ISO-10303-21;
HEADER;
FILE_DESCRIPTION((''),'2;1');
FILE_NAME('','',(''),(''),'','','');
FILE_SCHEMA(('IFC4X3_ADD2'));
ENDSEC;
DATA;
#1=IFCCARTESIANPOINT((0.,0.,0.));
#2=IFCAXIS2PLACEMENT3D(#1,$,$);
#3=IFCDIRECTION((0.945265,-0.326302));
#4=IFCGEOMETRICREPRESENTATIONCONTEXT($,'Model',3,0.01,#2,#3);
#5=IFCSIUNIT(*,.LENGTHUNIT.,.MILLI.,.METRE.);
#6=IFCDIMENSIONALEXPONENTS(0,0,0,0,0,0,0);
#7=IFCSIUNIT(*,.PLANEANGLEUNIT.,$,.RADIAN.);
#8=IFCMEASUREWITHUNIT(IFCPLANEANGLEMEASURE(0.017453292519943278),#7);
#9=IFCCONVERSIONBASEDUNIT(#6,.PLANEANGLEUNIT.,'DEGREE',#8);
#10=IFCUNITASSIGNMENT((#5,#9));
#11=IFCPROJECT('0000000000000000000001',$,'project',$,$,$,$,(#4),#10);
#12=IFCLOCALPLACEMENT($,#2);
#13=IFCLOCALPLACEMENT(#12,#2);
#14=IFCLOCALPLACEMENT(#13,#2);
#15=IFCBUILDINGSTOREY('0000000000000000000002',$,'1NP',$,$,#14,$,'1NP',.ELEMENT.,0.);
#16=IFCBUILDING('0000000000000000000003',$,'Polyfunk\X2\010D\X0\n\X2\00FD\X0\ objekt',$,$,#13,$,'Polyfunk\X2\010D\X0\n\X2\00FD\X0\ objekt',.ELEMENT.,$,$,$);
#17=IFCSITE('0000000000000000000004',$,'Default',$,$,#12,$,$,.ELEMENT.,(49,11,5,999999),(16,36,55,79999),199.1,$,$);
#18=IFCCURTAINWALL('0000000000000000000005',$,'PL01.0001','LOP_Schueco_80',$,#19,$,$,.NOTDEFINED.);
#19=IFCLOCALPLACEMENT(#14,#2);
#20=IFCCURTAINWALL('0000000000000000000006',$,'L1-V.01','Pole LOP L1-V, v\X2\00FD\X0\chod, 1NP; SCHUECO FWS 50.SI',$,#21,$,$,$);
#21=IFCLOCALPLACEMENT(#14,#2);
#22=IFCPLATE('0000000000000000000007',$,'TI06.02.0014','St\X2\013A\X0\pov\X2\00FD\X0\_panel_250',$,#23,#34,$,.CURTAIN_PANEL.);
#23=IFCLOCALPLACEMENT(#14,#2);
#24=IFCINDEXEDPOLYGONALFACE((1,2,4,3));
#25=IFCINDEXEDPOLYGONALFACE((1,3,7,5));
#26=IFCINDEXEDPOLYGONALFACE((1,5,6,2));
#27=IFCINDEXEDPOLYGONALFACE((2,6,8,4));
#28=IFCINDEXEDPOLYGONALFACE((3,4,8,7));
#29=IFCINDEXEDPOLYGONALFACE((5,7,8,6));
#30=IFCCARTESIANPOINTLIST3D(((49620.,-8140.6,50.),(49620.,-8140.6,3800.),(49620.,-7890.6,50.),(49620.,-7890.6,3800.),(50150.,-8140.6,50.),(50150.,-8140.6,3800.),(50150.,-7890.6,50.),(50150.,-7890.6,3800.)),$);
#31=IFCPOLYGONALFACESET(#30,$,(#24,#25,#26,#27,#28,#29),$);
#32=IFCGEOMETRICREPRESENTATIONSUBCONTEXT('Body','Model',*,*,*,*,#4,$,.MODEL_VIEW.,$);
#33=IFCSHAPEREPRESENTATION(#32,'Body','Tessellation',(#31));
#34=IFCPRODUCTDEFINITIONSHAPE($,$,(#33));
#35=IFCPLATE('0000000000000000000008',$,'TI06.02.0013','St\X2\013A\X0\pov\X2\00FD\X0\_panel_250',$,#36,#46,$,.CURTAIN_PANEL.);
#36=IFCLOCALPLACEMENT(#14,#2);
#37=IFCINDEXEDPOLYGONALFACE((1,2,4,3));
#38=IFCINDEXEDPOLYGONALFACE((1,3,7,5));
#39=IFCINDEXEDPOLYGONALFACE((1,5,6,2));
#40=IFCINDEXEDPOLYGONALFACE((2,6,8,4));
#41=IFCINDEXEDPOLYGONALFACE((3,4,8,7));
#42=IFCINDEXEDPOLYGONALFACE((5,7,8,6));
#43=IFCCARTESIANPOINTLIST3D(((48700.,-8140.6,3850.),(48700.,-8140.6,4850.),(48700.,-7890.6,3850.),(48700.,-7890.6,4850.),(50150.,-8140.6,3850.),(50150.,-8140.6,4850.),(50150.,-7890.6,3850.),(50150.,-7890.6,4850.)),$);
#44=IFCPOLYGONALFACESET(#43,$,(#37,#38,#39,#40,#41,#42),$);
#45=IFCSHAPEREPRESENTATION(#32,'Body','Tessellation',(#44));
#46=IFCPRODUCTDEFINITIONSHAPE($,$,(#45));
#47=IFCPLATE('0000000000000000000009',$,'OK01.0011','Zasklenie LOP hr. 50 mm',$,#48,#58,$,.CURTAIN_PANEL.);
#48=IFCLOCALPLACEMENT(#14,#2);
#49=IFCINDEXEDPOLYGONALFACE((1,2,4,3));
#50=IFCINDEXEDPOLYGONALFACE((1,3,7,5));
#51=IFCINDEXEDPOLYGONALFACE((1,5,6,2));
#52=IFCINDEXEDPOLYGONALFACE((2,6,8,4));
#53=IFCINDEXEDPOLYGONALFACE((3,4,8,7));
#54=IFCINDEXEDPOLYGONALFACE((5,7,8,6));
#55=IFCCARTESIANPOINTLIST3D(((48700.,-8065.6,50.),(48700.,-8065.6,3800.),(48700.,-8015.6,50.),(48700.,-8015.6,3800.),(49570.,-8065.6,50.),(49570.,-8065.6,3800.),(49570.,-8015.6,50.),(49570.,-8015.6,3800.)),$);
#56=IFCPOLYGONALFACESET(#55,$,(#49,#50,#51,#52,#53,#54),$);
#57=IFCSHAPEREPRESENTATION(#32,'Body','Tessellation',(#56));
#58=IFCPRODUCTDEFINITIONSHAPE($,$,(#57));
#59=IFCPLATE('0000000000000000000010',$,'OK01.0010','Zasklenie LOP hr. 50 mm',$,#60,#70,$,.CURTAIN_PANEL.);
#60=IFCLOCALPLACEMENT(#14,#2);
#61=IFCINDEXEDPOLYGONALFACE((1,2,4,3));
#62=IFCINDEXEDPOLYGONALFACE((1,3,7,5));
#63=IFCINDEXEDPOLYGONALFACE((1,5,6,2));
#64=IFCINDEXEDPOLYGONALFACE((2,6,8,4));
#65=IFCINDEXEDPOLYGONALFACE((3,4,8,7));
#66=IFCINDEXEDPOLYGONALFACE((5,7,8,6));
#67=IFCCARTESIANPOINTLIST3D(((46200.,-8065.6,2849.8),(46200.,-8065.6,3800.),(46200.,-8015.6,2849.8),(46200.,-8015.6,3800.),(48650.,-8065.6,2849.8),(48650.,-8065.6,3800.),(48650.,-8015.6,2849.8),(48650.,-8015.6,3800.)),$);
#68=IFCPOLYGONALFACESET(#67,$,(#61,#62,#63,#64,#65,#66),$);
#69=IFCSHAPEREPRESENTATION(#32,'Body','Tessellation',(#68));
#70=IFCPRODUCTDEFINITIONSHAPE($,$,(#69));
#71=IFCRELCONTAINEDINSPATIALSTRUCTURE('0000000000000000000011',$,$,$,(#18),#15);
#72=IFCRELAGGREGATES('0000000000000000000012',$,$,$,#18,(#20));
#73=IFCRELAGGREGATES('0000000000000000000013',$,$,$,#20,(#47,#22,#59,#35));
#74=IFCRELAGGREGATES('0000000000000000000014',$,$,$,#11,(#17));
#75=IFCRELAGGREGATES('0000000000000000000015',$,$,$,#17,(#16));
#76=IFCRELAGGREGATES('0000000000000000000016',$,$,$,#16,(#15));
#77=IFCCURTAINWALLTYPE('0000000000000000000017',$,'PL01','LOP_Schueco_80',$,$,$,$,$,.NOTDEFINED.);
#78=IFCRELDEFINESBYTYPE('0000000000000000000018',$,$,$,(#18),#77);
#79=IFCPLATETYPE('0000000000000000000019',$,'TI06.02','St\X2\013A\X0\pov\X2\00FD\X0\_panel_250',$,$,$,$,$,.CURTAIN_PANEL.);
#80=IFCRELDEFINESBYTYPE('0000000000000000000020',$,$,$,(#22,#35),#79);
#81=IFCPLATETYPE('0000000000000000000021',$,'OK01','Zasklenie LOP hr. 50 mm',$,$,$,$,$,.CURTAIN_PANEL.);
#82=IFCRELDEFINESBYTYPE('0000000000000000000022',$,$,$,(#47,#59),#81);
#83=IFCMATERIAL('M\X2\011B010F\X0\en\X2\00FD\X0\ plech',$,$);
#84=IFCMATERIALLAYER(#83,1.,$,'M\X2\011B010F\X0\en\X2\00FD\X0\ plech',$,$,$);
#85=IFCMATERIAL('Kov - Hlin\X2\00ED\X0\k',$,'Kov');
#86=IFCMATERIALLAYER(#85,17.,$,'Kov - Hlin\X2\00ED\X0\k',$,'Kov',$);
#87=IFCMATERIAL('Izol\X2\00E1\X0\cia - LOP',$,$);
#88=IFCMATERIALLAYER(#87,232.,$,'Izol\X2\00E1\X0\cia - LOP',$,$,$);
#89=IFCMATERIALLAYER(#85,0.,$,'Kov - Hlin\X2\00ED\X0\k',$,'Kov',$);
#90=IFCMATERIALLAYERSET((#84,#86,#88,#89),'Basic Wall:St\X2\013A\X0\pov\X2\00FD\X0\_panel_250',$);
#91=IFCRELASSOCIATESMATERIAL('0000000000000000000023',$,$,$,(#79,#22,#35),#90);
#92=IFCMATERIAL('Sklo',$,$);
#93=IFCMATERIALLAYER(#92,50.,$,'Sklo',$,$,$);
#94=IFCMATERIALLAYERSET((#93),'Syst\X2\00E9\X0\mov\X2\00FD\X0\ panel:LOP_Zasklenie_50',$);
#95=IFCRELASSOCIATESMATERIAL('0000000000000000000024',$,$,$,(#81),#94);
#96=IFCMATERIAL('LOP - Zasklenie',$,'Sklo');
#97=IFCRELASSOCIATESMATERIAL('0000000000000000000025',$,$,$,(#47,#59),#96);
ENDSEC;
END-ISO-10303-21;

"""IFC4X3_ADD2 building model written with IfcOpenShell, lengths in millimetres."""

from ifc_helpers import new_model, entity, si_unit, converted_unit, direction, frame, frame_2d, origin, origin_2d_with_axis, place, context, subcontext, project, spatial, rectangle, extrude, source, transform, mapped, material, layer, layer_set, layer_usage, type_object, type_shapes, element, aggregate, save


model = new_model("IFC4X3_ADD2")

# Units and contexts
model_context = context("Model", 3, precision=0.01, world=origin(), true_north=direction((0.945265, -0.326302)))
body_context = subcontext(model_context, "Body", "Model", "MODEL_VIEW")
ifc_project = project(units=[si_unit("LENGTHUNIT", "METRE", prefix="MILLI"), converted_unit("PLANEANGLEUNIT", "DEGREE", entity("IfcPlaneAngleMeasure", 0.017453292519943278), si_unit("PLANEANGLEUNIT", "RADIAN"), dimensions=[0, 0, 0, 0, 0, 0, 0])], contexts=[model_context])

# Site, building, storey
site_placement = place(None, origin())
site = spatial("IfcSite", under=ifc_project, at=site_placement, Name="Default", CompositionType="ELEMENT", RefLatitude=(49, 11, 5, 999999), RefLongitude=(16, 36, 55, 79999), RefElevation=199.1)
building_placement = place(site_placement, origin())
building = spatial("IfcBuilding", under=site, at=building_placement, Name="Polyfunkčný objekt", LongName="Polyfunkčný objekt", CompositionType="ELEMENT")
storey_placement = place(building_placement, origin())
storey = spatial("IfcBuildingStorey", under=building, at=storey_placement, Name="1NP", LongName="1NP", CompositionType="ELEMENT", Elevation=0.0)

# Curtain walls, plates
curtain_wall_type = type_object("IfcCurtainWallType", Name="PL01", Description="LOP_Schueco_80", PredefinedType="NOTDEFINED")
curtain_wall_1_placement = place(storey_placement, origin())
curtain_wall_1 = element("IfcCurtainWall", 1, at=curtain_wall_1_placement, inside=storey, type_object=curtain_wall_type, Name="PL01.0001", Description="LOP_Schueco_80", PredefinedType="NOTDEFINED")
curtain_wall_2 = element("IfcCurtainWall", 2, Name="L1-V.01", Description="Pole LOP L1-V, východ, 1NP; SCHUECO FWS 50.SI")
aggregate(curtain_wall_1, [curtain_wall_2])
ifc_material_1 = material(Name="Měďený plech")
ifc_layer_1 = layer(ifc_material_1, 1.0, Name="Měďený plech")
ifc_material_2 = material(Name="Kov - Hliník", Category="Kov")
ifc_layer_2 = layer(ifc_material_2, 17.0, Name="Kov - Hliník", Category="Kov")
ifc_material_3 = material(Name="Izolácia - LOP")
ifc_layer_3 = layer(ifc_material_3, 232.0, Name="Izolácia - LOP")
ifc_layer_4 = layer(ifc_material_2, 0.0, Name="Kov - Hliník", Category="Kov")
ifc_layer_set_1 = layer_set([ifc_layer_1, ifc_layer_2, ifc_layer_3, ifc_layer_4], Name="Basic Wall:Stĺpový_panel_250")
ifc_layer_usage_1 = layer_usage(ifc_layer_set_1, "AXIS2", "POSITIVE", -125.0)
plate_type_1 = type_object("IfcPlateType", Name="TI06.02", Description="Stĺpový_panel_250", PredefinedType="CURTAIN_PANEL", material=ifc_layer_set_1)
plate_1_placement = place(storey_placement, frame((49620.0, -8015.6, 50.0)))
plate_1 = element("IfcPlate", 3, at=plate_1_placement, type_object=plate_type_1, material=ifc_layer_usage_1, Name="TI06.02.0014", Description="Stĺpový_panel_250", PredefinedType="CURTAIN_PANEL", context=body_context, shape_type="SweptSolid", body=[
    extrude(rectangle(XDim=250.0, YDim=530.0, at=frame_2d((0.0, 0.0), x_axis=(1.0, 0.0))), frame((265.0, 0.0, 0.0), z_axis=(0.0, 0.0, 1.0), x_axis=(0.0, 1.0, 0.0)), (0.0, 0.0, 1.0), 3750.0),
])
ifc_layer_usage_2 = layer_usage(ifc_layer_set_1, "AXIS2", "POSITIVE", -125.0)
plate_2_placement = place(storey_placement, frame((48700.0, -8015.6, 3850.0)))
plate_2 = element("IfcPlate", 4, at=plate_2_placement, type_object=plate_type_1, material=ifc_layer_usage_2, Name="TI06.02.0013", Description="Stĺpový_panel_250", PredefinedType="CURTAIN_PANEL", context=body_context, shape_type="SweptSolid", body=[
    extrude(rectangle(XDim=250.0, YDim=1450.0, at=frame_2d((0.0, 0.0), x_axis=(1.0, 0.0))), frame((725.0, 0.0, 0.0), z_axis=(0.0, 0.0, 1.0), x_axis=(0.0, 1.0, 0.0)), (0.0, 0.0, 1.0), 1000.0),
])
ifc_material_4 = material(Name="LOP - Zasklenie", Category="Sklo")
ifc_material_5 = material(Name="Sklo")
ifc_layer_5 = layer(ifc_material_5, 50.0, Name="Sklo")
ifc_layer_set_2 = layer_set([ifc_layer_5], Name="Systémový panel:LOP_Zasklenie_50")
plate_type_2 = type_object("IfcPlateType", Name="OK01", Description="Zasklenie LOP hr. 50 mm", PredefinedType="CURTAIN_PANEL", material=ifc_layer_set_2)
shared_shape_1 = source(origin(), body_context, "Body", "SweptSolid", [
    extrude(rectangle(XDim=3750.0, YDim=870.0, at=frame_2d((-331.2, 0.0), x_axis=(1.0, 0.0))), frame((0.0, -50.0, 2206.2), z_axis=(0.0, 1.0, 0.0), x_axis=(0.0, 0.0, 1.0)), (0.0, 0.0, 1.0), 50.0),
])
plate_3_placement = place(curtain_wall_1_placement, frame((49135.0, -8015.6, 50.0)))
plate_3 = element("IfcPlate", 5, at=plate_3_placement, type_object=plate_type_2, material=ifc_material_4, Name="OK01.0011", Description="Zasklenie LOP hr. 50 mm", PredefinedType="CURTAIN_PANEL", context=body_context, shape_type="MappedRepresentation", body=[
    mapped(shared_shape_1, transform((0.0, 0.0, 0.0), scale=1.0)),
])
shared_shape_2 = source(origin(), body_context, "Body", "SweptSolid", [
    extrude(rectangle(XDim=50.0, YDim=2450.0, at=origin_2d_with_axis()), frame((0.0, -25.0, 0.0), z_axis=(0.0, 0.0, 1.0), x_axis=(0.0, 1.0, 0.0)), (0.0, 0.0, 1.0), 950.2),
])
type_shapes(plate_type_2, [shared_shape_1, shared_shape_2])
plate_4_placement = place(curtain_wall_1_placement, frame((47425.0, -8015.6, 2849.8)))
plate_4 = element("IfcPlate", 6, at=plate_4_placement, type_object=plate_type_2, material=ifc_material_4, Name="OK01.0010", Description="Zasklenie LOP hr. 50 mm", PredefinedType="CURTAIN_PANEL", context=body_context, shape_type="MappedRepresentation", body=[
    mapped(shared_shape_2, transform((0.0, 0.0, 0.0), scale=1.0)),
])
aggregate(curtain_wall_2, [plate_3, plate_1, plate_4, plate_2])

save(model, "model.ifc")
